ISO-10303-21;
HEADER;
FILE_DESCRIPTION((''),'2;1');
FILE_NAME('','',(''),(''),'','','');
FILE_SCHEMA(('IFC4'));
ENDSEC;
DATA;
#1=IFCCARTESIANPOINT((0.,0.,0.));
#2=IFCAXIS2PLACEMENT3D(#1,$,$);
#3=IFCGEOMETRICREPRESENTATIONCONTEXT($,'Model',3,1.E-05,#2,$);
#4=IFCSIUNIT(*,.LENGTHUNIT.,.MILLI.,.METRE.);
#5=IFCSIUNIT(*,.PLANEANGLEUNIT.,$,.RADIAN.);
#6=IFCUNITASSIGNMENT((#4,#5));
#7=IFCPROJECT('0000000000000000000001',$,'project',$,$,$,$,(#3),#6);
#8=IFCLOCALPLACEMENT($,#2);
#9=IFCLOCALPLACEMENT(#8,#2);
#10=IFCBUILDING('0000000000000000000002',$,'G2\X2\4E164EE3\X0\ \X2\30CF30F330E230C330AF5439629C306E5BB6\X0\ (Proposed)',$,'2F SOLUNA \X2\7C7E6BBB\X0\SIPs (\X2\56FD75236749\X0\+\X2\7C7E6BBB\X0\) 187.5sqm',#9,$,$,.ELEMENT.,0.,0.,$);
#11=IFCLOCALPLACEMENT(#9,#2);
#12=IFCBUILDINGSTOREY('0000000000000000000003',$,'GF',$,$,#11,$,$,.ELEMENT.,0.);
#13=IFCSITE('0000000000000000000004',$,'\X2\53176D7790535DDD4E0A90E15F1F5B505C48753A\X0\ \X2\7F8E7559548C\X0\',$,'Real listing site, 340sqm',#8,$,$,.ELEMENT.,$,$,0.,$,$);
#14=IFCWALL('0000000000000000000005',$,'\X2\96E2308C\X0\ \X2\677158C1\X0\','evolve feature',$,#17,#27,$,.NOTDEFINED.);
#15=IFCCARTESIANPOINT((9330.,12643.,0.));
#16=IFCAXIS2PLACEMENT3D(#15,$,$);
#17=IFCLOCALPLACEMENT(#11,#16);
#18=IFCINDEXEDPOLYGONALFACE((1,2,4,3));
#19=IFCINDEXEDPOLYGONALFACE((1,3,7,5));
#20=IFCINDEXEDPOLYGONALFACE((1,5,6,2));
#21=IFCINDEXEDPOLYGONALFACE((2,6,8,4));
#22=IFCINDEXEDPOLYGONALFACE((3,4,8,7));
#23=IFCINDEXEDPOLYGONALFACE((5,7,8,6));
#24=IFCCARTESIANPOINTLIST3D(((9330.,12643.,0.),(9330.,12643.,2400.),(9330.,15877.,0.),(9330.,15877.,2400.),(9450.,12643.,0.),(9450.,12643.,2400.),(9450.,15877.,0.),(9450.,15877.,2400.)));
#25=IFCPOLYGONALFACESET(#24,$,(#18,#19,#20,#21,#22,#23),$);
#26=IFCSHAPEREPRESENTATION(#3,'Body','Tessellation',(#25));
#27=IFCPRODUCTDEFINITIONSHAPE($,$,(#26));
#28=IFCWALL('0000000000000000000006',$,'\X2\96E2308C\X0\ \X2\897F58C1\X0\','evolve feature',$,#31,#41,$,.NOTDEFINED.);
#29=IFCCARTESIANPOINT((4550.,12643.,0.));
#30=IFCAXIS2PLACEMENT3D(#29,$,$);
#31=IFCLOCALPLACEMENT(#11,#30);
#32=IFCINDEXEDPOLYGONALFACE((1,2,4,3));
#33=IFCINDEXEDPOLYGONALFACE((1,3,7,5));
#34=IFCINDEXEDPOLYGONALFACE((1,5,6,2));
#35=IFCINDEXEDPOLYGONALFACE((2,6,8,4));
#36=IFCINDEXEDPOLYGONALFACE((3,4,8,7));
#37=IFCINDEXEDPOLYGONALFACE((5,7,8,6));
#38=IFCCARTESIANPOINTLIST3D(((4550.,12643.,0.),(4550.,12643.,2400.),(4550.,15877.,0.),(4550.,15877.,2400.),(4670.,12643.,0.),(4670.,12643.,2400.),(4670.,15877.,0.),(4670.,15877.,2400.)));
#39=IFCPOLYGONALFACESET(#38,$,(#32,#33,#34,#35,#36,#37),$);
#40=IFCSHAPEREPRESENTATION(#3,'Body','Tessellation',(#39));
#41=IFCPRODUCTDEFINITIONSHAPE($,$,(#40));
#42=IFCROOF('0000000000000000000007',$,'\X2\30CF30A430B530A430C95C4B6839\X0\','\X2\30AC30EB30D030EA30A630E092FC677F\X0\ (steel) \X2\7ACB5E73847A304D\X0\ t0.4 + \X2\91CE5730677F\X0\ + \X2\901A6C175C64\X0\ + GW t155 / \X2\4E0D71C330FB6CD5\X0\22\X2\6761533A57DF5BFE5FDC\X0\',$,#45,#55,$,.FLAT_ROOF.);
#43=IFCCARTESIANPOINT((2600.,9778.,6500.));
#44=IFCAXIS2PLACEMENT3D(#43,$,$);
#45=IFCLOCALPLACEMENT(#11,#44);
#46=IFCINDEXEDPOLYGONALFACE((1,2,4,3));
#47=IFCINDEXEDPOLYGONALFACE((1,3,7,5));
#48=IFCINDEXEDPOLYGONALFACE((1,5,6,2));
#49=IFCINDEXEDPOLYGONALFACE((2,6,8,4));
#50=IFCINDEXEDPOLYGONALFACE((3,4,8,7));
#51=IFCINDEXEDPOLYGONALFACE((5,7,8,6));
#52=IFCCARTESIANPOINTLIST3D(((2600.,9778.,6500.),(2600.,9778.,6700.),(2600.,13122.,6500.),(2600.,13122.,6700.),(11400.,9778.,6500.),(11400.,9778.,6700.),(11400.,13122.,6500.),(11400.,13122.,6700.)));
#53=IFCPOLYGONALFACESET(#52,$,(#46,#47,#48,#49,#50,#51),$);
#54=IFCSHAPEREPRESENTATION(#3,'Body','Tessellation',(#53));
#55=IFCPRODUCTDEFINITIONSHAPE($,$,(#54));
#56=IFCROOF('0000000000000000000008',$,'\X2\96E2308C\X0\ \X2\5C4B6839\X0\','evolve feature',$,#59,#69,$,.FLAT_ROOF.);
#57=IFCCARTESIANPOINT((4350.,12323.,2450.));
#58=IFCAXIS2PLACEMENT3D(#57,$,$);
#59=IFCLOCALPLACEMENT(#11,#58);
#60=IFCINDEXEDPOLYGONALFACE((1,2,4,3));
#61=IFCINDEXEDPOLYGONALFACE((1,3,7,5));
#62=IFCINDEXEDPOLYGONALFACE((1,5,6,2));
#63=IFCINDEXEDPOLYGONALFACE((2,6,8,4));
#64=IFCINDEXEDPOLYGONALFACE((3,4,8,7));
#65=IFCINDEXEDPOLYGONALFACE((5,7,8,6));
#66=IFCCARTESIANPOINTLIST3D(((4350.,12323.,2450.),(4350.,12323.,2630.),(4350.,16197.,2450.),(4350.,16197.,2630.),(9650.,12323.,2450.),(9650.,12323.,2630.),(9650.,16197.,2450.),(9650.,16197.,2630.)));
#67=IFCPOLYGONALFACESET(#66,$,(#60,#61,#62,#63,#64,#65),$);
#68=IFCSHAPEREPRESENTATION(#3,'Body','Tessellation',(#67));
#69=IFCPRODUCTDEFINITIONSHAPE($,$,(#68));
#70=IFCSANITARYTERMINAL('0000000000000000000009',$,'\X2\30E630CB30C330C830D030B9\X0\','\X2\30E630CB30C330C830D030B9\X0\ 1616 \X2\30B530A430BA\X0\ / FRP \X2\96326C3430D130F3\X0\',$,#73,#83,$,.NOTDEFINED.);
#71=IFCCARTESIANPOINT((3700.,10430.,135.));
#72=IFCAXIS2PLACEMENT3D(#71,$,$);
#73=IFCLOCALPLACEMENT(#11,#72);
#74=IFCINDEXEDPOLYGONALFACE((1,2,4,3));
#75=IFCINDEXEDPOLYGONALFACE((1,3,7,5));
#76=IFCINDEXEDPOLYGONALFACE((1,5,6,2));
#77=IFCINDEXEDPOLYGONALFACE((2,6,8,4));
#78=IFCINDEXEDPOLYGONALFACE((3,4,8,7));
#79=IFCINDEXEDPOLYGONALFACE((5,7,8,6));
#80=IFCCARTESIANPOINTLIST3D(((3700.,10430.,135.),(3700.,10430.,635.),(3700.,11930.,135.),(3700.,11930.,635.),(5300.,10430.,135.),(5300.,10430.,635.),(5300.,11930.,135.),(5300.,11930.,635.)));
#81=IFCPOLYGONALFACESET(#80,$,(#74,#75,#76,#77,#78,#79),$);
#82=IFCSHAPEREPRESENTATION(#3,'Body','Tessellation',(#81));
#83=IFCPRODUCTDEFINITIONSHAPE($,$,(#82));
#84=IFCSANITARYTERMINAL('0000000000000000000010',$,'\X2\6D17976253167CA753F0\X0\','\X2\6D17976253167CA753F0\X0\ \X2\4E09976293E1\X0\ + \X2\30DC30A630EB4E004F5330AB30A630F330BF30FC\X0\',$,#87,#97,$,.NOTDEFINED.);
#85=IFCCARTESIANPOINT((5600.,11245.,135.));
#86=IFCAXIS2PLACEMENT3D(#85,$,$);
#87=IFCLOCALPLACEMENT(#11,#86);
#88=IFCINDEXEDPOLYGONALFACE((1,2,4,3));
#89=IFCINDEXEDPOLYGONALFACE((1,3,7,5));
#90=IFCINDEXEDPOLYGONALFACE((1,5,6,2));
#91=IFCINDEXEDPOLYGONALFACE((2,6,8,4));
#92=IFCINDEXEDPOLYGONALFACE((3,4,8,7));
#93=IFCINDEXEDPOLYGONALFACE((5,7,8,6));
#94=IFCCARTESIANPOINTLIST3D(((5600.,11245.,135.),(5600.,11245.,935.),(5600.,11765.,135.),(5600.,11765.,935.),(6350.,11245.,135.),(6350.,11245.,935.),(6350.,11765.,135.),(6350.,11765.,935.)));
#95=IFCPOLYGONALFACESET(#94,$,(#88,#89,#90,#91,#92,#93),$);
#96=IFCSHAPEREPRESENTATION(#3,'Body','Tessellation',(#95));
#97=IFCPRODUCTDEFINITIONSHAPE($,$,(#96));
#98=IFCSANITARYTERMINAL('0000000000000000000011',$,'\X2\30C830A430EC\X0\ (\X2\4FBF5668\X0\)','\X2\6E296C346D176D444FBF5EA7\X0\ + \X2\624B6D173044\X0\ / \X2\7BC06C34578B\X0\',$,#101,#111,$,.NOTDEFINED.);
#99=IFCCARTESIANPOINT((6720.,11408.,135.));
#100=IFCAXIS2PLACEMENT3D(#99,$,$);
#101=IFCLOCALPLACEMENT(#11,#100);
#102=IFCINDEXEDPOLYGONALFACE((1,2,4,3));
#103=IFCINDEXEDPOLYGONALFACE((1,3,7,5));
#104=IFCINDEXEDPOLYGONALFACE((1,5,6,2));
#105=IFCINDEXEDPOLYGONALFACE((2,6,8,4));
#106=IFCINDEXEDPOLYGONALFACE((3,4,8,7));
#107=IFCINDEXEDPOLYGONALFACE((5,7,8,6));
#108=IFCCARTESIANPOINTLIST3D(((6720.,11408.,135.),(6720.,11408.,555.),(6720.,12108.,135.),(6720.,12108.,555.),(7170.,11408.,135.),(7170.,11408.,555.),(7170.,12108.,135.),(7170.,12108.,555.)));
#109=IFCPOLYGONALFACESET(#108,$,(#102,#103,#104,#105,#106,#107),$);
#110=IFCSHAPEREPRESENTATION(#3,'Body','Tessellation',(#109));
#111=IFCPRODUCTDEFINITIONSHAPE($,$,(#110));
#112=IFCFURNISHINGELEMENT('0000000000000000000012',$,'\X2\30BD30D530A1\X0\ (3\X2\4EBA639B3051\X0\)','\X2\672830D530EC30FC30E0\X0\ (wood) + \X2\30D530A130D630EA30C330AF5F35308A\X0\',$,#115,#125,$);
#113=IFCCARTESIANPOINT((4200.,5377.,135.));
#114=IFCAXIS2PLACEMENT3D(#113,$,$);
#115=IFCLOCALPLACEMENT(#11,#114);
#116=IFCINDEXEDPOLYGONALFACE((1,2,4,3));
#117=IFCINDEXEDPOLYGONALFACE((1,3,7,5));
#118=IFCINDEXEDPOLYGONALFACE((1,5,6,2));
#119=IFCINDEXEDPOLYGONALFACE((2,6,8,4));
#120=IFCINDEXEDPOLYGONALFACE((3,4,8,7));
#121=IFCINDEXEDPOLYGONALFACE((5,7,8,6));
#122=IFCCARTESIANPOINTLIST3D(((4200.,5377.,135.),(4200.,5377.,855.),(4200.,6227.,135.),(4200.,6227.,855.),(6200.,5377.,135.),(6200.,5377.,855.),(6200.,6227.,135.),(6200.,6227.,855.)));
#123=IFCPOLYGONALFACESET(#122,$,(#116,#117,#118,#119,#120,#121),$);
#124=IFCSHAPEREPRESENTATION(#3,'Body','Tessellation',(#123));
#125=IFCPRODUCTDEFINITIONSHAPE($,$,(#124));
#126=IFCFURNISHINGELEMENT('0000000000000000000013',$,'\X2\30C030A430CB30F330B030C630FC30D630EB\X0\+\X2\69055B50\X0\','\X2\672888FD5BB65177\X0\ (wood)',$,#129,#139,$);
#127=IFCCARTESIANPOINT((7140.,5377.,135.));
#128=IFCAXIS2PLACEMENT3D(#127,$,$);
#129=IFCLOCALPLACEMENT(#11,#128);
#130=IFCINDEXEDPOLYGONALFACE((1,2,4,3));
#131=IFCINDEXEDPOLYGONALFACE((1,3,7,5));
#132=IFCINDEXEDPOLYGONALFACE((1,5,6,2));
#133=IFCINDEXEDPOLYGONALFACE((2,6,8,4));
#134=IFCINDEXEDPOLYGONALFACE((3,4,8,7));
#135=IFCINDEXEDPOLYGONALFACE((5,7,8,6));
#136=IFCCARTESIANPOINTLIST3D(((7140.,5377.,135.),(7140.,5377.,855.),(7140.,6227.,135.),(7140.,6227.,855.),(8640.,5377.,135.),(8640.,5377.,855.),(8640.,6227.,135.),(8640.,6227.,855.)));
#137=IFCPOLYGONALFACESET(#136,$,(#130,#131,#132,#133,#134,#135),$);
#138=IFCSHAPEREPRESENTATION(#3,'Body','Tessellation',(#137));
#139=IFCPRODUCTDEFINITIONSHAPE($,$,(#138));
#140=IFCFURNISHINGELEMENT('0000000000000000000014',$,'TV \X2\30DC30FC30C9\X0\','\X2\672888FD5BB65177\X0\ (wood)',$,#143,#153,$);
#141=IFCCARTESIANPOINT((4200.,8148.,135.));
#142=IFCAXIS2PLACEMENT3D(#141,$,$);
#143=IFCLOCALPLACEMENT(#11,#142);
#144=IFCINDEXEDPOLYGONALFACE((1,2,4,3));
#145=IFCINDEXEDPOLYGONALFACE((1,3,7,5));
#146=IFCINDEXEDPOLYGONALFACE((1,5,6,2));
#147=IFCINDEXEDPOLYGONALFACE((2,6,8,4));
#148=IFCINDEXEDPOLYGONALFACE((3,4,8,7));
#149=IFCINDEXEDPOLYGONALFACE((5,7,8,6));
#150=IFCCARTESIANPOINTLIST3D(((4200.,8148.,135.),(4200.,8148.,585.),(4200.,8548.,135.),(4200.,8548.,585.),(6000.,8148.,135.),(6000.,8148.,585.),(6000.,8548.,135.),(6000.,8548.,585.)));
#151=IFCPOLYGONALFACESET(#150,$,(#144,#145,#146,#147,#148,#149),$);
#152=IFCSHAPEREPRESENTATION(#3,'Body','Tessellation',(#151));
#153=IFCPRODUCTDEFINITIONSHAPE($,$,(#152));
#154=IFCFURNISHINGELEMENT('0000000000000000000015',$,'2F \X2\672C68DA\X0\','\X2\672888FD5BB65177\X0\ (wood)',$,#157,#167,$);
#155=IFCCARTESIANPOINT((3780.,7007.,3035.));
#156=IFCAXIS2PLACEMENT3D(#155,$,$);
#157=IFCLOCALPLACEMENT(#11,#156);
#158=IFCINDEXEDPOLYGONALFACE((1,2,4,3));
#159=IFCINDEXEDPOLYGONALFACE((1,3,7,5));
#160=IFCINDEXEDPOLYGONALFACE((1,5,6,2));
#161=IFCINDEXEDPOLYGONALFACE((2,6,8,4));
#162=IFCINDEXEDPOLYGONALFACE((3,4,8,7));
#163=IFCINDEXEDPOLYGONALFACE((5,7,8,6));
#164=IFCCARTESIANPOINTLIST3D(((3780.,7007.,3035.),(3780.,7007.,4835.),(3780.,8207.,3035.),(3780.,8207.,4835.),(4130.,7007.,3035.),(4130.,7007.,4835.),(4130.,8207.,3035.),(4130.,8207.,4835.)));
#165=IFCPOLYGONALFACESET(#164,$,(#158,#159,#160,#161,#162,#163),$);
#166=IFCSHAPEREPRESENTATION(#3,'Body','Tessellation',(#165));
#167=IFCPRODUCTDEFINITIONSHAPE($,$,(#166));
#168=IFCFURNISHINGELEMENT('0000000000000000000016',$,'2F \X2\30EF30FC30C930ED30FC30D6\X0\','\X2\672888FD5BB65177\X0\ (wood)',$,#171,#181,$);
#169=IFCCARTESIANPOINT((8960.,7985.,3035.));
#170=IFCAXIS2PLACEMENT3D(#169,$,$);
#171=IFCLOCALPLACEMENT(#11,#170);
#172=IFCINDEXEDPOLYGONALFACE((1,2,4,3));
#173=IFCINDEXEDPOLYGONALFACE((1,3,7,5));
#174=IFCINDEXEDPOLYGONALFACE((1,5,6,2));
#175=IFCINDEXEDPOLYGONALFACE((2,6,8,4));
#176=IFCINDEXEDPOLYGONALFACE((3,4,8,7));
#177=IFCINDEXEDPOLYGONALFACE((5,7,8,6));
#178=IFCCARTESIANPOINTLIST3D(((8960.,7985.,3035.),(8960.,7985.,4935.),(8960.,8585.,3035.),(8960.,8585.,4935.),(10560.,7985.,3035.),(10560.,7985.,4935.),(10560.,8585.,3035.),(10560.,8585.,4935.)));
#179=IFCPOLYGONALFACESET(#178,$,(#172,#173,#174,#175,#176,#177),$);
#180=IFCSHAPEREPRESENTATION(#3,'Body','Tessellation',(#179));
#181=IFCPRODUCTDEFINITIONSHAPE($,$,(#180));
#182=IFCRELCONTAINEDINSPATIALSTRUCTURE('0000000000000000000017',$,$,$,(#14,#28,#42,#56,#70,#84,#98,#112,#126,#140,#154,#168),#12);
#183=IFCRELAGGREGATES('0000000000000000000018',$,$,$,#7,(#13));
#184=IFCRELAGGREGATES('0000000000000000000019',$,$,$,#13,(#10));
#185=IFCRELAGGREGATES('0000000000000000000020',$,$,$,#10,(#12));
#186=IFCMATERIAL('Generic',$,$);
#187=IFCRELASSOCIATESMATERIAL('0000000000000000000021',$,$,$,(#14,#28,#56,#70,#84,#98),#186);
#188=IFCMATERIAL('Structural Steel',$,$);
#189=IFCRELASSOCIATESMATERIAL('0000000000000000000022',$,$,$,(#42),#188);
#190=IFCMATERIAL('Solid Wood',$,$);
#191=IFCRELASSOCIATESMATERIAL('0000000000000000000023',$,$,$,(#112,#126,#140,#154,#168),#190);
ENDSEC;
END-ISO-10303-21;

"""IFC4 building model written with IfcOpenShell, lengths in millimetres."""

from ifc_helpers import new_model, si_unit, frame, frame_2d, origin, place, context, project, spatial, rectangle, extrude, material, element, save


model = new_model("IFC4")

# Units and contexts
model_context = context("Model", 3, precision=1e-05, world=origin())
ifc_project = project(units=[si_unit("LENGTHUNIT", "METRE", prefix="MILLI"), si_unit("PLANEANGLEUNIT", "RADIAN")], contexts=[model_context])

# Site, building, storey
site_placement = place(None, origin())
site = spatial("IfcSite", under=ifc_project, at=site_placement, Name="北海道川上郡弟子屈町 美留和", ObjectType="Real listing site, 340sqm", CompositionType="ELEMENT", RefElevation=0.0)
building_placement = place(site_placement, origin())
building = spatial("IfcBuilding", under=site, at=building_placement, Name="G2世代 ハンモック吹抜の家 (Proposed)", ObjectType="2F SOLUNA 籾殻SIPs (国産杉+籾殻) 187.5sqm", CompositionType="ELEMENT", ElevationOfRefHeight=0.0, ElevationOfTerrain=0.0)
storey_placement = place(building_placement, origin())
storey = spatial("IfcBuildingStorey", under=building, at=storey_placement, Name="GF", CompositionType="ELEMENT", Elevation=0.0)

# Shared definitions
ifc_material_1 = material(Name="Generic")

# Shared definitions
ifc_material_2 = material(Name="Solid Wood")

# Walls
wall_1_placement = place(storey_placement, frame((9330.0, 12643.0, 0.0)))
element("IfcWall", 1, at=wall_1_placement, inside=storey, material=ifc_material_1, Name="離れ 東壁", Description="evolve feature", PredefinedType="NOTDEFINED", context=model_context, shape_type="SweptSolid", body=[
    extrude(rectangle(XDim=120.0, YDim=3234.0, at=frame_2d((60.0, 1617.0))), frame((9330.0, 12643.0, 0.0)), (0.0, 0.0, 1.0), 2400.0),
])
wall_2_placement = place(storey_placement, frame((4550.0, 12643.0, 0.0)))
element("IfcWall", 2, at=wall_2_placement, inside=storey, material=ifc_material_1, Name="離れ 西壁", Description="evolve feature", PredefinedType="NOTDEFINED", context=model_context, shape_type="SweptSolid", body=[
    extrude(rectangle(XDim=120.0, YDim=3234.0, at=frame_2d((60.0, 1617.0))), frame((4550.0, 12643.0, 0.0)), (0.0, 0.0, 1.0), 2400.0),
])

# Roofs
ifc_material_3 = material(Name="Structural Steel")
roof_1_placement = place(storey_placement, frame((2600.0, 9778.0, 6500.0)))
element("IfcRoof", 3, at=roof_1_placement, inside=storey, material=ifc_material_3, Name="ハイサイド屋根", Description="ガルバリウム鋼板 (steel) 立平葺き t0.4 + 野地板 + 通気層 + GW t155 / 不燃・法22条区域対応", PredefinedType="FLAT_ROOF", context=model_context, shape_type="SweptSolid", body=[
    extrude(rectangle(XDim=8800.0, YDim=3344.0, at=frame_2d((4400.0, 1672.0))), frame((2600.0, 9778.0, 6500.0)), (0.0, 0.0, 1.0), 200.0),
])
roof_2_placement = place(storey_placement, frame((4350.0, 12323.0, 2450.0)))
element("IfcRoof", 4, at=roof_2_placement, inside=storey, material=ifc_material_1, Name="離れ 屋根", Description="evolve feature", PredefinedType="FLAT_ROOF", context=model_context, shape_type="SweptSolid", body=[
    extrude(rectangle(XDim=5300.0, YDim=3874.0, at=frame_2d((2650.0, 1937.0))), frame((4350.0, 12323.0, 2450.0)), (0.0, 0.0, 1.0), 180.0),
])

# Sanitary terminals
sanitary_terminal_1_placement = place(storey_placement, frame((3700.0, 10430.0, 135.0)))
element("IfcSanitaryTerminal", 5, at=sanitary_terminal_1_placement, inside=storey, material=ifc_material_1, Name="ユニットバス", Description="ユニットバス 1616 サイズ / FRP 防水パン", PredefinedType="NOTDEFINED", context=model_context, shape_type="SweptSolid", body=[
    extrude(rectangle(XDim=1600.0, YDim=1500.0, at=frame_2d((800.0, 750.0))), frame((3700.0, 10430.0, 135.0)), (0.0, 0.0, 1.0), 500.0),
])
sanitary_terminal_2_placement = place(storey_placement, frame((5600.0, 11245.0, 135.0)))
element("IfcSanitaryTerminal", 6, at=sanitary_terminal_2_placement, inside=storey, material=ifc_material_1, Name="洗面化粧台", Description="洗面化粧台 三面鏡 + ボウル一体カウンター", PredefinedType="NOTDEFINED", context=model_context, shape_type="SweptSolid", body=[
    extrude(rectangle(XDim=750.0, YDim=520.0, at=frame_2d((375.0, 260.0))), frame((5600.0, 11245.0, 135.0)), (0.0, 0.0, 1.0), 800.0),
])
sanitary_terminal_3_placement = place(storey_placement, frame((6720.0, 11408.0, 135.0)))
element("IfcSanitaryTerminal", 7, at=sanitary_terminal_3_placement, inside=storey, material=ifc_material_1, Name="トイレ (便器)", Description="温水洗浄便座 + 手洗い / 節水型", PredefinedType="NOTDEFINED", context=model_context, shape_type="SweptSolid", body=[
    extrude(rectangle(XDim=450.0, YDim=700.0, at=frame_2d((225.0, 350.0))), frame((6720.0, 11408.0, 135.0)), (0.0, 0.0, 1.0), 420.0),
])

# Furnishing elements
furnishing_1_placement = place(storey_placement, frame((4200.0, 5377.0, 135.0)))
element("IfcFurnishingElement", 8, at=furnishing_1_placement, inside=storey, material=ifc_material_2, Name="ソファ (3人掛け)", Description="木フレーム (wood) + ファブリック張り", context=model_context, shape_type="SweptSolid", body=[
    extrude(rectangle(XDim=2000.0, YDim=850.0, at=frame_2d((1000.0, 425.0))), frame((4200.0, 5377.0, 135.0)), (0.0, 0.0, 1.0), 720.0),
])
furnishing_2_placement = place(storey_placement, frame((7140.0, 5377.0, 135.0)))
element("IfcFurnishingElement", 9, at=furnishing_2_placement, inside=storey, material=ifc_material_2, Name="ダイニングテーブル+椅子", Description="木製家具 (wood)", context=model_context, shape_type="SweptSolid", body=[
    extrude(rectangle(XDim=1500.0, YDim=850.0, at=frame_2d((750.0, 425.0))), frame((7140.0, 5377.0, 135.0)), (0.0, 0.0, 1.0), 720.0),
])
furnishing_3_placement = place(storey_placement, frame((4200.0, 8148.0, 135.0)))
element("IfcFurnishingElement", 10, at=furnishing_3_placement, inside=storey, material=ifc_material_2, Name="TV ボード", Description="木製家具 (wood)", context=model_context, shape_type="SweptSolid", body=[
    extrude(rectangle(XDim=1800.0, YDim=400.0, at=frame_2d((900.0, 200.0))), frame((4200.0, 8148.0, 135.0)), (0.0, 0.0, 1.0), 450.0),
])
furnishing_4_placement = place(storey_placement, frame((3780.0, 7007.0, 3035.0)))
element("IfcFurnishingElement", 11, at=furnishing_4_placement, inside=storey, material=ifc_material_2, Name="2F 本棚", Description="木製家具 (wood)", context=model_context, shape_type="SweptSolid", body=[
    extrude(rectangle(XDim=350.0, YDim=1200.0, at=frame_2d((175.0, 600.0))), frame((3780.0, 7007.0, 3035.0)), (0.0, 0.0, 1.0), 1800.0),
])
furnishing_5_placement = place(storey_placement, frame((8960.0, 7985.0, 3035.0)))
element("IfcFurnishingElement", 12, at=furnishing_5_placement, inside=storey, material=ifc_material_2, Name="2F ワードローブ", Description="木製家具 (wood)", context=model_context, shape_type="SweptSolid", body=[
    extrude(rectangle(XDim=1600.0, YDim=600.0, at=frame_2d((800.0, 300.0))), frame((8960.0, 7985.0, 3035.0)), (0.0, 0.0, 1.0), 1900.0),
])

save(model, "model.ifc")
